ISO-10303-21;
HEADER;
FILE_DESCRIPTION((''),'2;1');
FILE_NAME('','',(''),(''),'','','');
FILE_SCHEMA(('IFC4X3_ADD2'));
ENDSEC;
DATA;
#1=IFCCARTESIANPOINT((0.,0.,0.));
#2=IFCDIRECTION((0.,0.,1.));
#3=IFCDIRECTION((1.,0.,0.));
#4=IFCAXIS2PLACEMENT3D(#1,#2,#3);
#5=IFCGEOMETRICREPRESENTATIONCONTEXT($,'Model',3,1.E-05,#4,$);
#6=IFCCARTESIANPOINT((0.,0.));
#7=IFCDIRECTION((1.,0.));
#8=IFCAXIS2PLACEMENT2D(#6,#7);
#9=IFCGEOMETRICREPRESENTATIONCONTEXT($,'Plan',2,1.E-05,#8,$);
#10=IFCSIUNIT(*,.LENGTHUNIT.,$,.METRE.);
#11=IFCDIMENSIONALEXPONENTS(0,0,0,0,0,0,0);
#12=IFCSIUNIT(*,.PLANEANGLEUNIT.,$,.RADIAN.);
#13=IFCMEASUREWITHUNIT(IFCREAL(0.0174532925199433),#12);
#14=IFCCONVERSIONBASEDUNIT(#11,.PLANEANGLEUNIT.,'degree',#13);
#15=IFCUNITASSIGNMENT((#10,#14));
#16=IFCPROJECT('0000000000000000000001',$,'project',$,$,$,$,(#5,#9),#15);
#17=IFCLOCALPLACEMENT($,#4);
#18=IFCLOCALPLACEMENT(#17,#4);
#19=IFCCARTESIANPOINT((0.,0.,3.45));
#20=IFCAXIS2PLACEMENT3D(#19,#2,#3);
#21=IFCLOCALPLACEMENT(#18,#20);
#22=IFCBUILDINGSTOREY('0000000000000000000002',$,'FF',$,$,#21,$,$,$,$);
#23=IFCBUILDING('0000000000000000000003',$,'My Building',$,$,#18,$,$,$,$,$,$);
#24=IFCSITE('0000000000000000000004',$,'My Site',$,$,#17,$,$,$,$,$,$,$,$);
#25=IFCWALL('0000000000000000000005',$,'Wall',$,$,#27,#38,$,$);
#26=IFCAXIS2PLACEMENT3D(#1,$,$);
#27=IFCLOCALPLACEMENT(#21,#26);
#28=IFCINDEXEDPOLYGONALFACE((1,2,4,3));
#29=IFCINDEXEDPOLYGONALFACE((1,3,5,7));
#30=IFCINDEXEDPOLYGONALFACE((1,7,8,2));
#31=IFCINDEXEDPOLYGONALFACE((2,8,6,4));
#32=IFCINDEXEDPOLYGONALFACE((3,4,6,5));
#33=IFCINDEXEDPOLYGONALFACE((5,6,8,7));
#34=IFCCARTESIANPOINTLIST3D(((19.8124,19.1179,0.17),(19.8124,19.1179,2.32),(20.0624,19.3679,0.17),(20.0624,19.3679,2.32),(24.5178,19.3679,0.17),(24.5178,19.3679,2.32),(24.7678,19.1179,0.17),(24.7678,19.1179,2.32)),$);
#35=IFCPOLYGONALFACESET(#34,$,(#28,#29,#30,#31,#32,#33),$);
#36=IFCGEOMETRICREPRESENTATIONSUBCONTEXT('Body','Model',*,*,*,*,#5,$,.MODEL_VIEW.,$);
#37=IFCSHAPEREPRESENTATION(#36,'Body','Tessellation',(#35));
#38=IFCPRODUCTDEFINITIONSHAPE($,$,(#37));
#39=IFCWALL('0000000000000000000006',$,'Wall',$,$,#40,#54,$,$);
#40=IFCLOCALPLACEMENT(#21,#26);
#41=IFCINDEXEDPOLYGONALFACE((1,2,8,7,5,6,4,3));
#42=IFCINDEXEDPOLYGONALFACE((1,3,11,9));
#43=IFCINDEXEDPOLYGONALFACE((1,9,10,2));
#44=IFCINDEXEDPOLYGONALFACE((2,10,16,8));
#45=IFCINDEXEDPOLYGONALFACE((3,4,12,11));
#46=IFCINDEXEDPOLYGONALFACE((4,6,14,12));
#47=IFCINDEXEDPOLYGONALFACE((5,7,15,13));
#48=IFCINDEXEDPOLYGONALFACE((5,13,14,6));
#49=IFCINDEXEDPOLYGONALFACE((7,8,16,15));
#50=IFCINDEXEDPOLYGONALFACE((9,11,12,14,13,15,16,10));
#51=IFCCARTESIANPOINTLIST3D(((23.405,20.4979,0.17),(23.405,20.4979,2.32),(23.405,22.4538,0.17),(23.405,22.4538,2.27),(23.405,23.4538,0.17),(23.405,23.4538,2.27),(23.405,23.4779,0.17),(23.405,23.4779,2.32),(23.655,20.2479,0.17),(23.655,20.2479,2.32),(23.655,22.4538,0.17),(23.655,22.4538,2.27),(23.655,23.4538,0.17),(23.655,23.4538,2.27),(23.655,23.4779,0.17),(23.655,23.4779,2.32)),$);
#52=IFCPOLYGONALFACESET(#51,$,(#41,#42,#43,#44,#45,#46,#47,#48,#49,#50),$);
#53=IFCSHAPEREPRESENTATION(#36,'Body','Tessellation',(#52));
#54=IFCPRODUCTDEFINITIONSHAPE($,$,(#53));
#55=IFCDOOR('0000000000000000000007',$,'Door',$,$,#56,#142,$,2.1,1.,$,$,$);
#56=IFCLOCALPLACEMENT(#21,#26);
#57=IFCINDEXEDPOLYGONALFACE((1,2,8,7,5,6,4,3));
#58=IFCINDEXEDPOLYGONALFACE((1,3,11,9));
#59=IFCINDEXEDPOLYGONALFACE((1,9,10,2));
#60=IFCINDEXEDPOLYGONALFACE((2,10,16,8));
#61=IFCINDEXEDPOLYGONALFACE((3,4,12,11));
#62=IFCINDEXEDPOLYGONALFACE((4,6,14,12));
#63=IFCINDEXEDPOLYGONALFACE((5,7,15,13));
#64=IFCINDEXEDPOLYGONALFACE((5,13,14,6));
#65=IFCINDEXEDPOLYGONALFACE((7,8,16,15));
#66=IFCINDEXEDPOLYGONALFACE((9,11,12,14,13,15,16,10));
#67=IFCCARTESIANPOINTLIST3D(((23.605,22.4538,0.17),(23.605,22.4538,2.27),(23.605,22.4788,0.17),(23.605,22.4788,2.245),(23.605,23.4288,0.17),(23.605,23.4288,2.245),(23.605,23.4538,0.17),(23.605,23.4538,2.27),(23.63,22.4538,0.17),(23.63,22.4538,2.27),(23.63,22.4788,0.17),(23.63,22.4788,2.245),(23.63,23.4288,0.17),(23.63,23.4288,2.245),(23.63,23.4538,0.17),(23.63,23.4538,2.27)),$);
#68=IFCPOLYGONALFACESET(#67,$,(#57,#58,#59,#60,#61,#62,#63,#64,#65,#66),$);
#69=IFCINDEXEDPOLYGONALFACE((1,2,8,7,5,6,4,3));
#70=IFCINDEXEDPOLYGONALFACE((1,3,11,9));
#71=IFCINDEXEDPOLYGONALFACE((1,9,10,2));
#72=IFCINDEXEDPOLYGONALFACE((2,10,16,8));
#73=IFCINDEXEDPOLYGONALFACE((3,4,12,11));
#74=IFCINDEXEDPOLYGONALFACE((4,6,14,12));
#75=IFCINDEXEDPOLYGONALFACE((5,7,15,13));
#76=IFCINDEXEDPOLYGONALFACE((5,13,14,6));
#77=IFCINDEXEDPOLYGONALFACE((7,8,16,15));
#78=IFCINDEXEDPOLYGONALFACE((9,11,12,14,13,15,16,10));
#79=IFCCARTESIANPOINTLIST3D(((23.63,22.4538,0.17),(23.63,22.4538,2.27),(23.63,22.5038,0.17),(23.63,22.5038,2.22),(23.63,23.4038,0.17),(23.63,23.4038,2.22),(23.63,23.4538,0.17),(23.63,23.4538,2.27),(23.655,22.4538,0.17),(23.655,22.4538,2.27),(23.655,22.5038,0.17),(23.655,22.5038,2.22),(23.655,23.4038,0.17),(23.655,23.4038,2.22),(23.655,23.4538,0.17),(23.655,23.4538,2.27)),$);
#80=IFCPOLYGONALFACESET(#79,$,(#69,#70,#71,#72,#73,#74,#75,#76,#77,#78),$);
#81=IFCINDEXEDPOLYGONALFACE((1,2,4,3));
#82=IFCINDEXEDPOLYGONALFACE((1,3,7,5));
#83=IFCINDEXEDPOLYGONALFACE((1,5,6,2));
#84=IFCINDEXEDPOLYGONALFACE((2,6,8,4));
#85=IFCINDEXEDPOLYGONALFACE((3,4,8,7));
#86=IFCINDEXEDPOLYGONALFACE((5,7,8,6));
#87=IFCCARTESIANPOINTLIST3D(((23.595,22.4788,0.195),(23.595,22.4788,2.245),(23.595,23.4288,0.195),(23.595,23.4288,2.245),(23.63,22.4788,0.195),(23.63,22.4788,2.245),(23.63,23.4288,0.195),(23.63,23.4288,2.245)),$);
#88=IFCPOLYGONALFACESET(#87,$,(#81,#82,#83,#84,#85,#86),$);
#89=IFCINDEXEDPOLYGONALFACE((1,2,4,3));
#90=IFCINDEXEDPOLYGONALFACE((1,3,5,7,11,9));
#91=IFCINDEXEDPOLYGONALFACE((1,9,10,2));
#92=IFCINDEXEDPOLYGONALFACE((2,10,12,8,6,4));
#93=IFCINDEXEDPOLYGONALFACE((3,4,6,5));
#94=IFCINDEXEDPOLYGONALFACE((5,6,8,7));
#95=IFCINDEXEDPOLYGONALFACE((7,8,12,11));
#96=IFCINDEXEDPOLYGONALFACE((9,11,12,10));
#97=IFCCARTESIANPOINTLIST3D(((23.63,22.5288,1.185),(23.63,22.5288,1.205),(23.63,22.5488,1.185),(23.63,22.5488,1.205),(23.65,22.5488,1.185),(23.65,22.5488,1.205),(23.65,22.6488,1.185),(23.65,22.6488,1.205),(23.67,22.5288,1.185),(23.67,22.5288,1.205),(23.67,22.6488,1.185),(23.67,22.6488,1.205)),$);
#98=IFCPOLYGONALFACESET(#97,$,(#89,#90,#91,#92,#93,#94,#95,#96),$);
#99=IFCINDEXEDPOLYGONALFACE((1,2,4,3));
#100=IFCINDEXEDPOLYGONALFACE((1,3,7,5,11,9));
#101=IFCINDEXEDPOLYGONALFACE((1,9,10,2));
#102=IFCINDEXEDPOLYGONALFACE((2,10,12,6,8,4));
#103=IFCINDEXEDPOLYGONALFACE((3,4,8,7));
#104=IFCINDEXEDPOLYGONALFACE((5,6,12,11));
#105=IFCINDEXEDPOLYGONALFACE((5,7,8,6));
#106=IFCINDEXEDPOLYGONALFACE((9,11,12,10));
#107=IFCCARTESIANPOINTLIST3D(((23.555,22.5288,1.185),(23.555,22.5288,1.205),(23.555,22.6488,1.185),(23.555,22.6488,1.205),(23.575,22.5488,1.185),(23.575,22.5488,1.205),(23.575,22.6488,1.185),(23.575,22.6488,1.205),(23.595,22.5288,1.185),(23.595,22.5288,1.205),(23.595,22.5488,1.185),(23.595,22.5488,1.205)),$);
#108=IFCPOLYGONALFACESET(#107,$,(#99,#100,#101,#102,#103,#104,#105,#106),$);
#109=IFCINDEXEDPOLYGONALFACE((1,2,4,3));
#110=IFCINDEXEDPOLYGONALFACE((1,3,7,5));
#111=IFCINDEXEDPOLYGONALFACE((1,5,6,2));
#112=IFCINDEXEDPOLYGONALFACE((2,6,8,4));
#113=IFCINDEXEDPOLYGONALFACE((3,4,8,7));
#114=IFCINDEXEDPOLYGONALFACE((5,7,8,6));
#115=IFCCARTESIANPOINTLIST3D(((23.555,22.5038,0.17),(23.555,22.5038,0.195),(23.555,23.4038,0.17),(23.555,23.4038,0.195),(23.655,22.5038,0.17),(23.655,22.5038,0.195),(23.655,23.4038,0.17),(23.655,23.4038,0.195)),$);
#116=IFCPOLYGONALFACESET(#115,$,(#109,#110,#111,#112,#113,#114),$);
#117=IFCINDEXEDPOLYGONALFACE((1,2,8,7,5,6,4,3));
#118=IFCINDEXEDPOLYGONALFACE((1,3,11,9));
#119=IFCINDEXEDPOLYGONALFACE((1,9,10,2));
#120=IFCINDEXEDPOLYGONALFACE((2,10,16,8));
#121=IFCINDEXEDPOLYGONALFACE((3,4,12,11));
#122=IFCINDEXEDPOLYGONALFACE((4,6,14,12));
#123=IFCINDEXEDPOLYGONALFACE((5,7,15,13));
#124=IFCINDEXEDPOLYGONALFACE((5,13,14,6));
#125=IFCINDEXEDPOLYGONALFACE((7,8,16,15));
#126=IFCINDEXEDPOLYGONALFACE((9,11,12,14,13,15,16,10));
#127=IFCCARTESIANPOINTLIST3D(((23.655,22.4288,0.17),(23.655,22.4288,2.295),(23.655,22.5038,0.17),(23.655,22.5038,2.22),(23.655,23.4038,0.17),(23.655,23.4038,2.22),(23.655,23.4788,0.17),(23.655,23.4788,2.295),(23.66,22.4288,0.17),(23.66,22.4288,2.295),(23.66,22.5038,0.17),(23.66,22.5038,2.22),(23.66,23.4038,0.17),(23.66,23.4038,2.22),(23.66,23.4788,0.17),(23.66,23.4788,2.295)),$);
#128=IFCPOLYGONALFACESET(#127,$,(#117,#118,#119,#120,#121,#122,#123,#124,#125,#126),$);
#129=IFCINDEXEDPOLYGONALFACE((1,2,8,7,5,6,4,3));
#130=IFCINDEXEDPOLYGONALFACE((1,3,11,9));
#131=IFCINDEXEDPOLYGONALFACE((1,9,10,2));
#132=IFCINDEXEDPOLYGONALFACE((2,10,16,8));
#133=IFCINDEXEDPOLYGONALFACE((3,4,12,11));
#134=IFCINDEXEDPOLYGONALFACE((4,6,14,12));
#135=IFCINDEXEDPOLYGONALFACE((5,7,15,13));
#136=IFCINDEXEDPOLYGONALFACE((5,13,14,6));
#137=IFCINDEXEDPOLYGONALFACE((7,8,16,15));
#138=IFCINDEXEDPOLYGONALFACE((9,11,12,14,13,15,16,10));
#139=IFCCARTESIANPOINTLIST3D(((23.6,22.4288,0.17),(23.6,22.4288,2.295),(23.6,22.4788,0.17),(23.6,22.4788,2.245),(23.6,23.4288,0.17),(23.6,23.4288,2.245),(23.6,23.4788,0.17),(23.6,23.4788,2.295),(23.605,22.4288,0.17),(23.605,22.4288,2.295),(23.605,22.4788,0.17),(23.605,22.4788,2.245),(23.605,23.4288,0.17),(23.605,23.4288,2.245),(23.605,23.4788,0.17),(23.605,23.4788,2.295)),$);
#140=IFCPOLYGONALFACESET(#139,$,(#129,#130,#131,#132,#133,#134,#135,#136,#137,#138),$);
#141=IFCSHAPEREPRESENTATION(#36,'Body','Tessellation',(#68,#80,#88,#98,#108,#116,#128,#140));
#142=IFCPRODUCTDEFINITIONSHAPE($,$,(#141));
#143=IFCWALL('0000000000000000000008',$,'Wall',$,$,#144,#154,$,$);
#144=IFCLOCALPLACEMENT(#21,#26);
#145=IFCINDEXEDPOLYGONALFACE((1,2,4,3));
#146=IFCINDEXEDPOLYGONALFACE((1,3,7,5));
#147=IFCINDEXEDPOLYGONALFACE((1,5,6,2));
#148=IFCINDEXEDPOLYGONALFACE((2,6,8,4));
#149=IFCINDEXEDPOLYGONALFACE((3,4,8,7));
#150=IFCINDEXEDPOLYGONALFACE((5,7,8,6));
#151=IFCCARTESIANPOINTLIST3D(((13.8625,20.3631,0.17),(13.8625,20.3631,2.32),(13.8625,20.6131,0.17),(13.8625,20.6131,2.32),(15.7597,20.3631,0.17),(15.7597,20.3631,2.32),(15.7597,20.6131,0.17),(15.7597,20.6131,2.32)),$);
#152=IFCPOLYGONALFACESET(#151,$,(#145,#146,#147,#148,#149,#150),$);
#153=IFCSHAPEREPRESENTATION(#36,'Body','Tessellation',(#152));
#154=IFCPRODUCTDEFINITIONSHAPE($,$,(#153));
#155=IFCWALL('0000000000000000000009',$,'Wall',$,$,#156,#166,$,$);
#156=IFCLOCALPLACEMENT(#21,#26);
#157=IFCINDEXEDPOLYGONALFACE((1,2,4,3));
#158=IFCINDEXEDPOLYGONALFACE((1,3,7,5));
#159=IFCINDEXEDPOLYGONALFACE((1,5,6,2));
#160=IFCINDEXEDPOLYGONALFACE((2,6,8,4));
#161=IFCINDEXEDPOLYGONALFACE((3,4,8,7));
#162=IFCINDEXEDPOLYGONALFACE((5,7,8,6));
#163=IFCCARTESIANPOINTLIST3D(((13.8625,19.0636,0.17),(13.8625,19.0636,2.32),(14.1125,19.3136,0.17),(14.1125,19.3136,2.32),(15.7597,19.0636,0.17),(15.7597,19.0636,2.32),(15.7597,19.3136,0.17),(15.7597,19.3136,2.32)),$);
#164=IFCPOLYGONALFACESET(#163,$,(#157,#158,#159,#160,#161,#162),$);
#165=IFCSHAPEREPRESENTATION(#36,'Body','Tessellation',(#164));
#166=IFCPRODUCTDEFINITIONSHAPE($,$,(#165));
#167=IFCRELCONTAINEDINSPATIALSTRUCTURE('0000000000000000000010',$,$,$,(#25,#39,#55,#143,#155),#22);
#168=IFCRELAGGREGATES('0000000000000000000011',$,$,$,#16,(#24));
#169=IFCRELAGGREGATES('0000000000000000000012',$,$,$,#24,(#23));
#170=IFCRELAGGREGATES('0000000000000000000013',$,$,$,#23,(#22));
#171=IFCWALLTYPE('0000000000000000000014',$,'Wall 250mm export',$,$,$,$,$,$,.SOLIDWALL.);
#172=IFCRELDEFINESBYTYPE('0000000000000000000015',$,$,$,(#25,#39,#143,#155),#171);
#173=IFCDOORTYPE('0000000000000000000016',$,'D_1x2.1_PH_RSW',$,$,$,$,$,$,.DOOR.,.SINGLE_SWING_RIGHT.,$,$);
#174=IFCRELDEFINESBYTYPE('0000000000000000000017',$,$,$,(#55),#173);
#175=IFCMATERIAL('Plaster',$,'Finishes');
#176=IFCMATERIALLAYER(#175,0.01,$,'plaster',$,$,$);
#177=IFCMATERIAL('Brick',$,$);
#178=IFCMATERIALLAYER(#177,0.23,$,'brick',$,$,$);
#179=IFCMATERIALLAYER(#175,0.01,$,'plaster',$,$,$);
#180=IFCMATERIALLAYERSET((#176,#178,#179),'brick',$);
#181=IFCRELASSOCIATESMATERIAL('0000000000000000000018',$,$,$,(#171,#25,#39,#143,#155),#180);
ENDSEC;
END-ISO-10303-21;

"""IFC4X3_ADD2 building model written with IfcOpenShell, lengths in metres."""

from ifc_helpers import new_model, entity, si_unit, converted_unit, frame, origin_with_axes, origin_2d_with_axis, place, context, subcontext, project, spatial, line, indexed_curve, outline, extrude, shape, source, transform, mapped, material, layer, layer_set, layer_usage, type_object, type_shapes, element, fill, save


model = new_model("IFC4X3_ADD2")

# Units and contexts
model_context = context("Model", 3, precision=1e-05, world=origin_with_axes())
plan_context = context("Plan", 2, precision=1e-05, world=origin_2d_with_axis())
body_context_1 = subcontext(model_context, "Body", "Model", "MODEL_VIEW")
body_context_2 = subcontext(plan_context, "Body", "Plan", "PLAN_VIEW")
ifc_project = project(units=[si_unit("LENGTHUNIT", "METRE"), converted_unit("PLANEANGLEUNIT", "degree", entity("IfcReal", 0.0174532925199433), si_unit("PLANEANGLEUNIT", "RADIAN"), dimensions=[0, 0, 0, 0, 0, 0, 0])], contexts=[model_context, plan_context])

# Site, building, storey
site_placement = place(None, origin_with_axes())
site = spatial("IfcSite", under=ifc_project, at=site_placement, Name="My Site")
building_placement = place(site_placement, origin_with_axes())
building = spatial("IfcBuilding", under=site, at=building_placement, Name="My Building")
storey_placement = place(building_placement, frame((0.0, 0.0, 3.45), z_axis=(0.0, 0.0, 1.0), x_axis=(1.0, 0.0, 0.0)))
storey = spatial("IfcBuildingStorey", under=building, at=storey_placement, Name="FF")

# Shared definitions
ifc_material_1 = material(Name="Plaster", Category="Finishes")
ifc_layer_1 = layer(ifc_material_1, 0.01, Name="plaster")
ifc_material_2 = material(Name="Brick")
ifc_layer_2 = layer(ifc_material_2, 0.23, Name="brick")
ifc_layer_3 = layer(ifc_material_1, 0.01, Name="plaster")
ifc_layer_set_1 = layer_set([ifc_layer_1, ifc_layer_2, ifc_layer_3], Name="brick")
wall_type_1 = type_object("IfcWallType", Name="Wall 250mm export", PredefinedType="SOLIDWALL", material=ifc_layer_set_1)

# Wall
ifc_layer_usage_1 = layer_usage(ifc_layer_set_1, "AXIS2", "POSITIVE", 0.0)
wall_1_placement = place(storey_placement, frame((20.0624, 19.1179, 0.17), z_axis=(0.0, 0.0, 1.0), x_axis=(1.0, 0.0, 0.0)))
element("IfcWall", 1, at=wall_1_placement, inside=storey, type_object=wall_type_1, material=ifc_layer_usage_1, Name="Wall", context=body_context_1, shape_type="SweptSolid", body=[
    extrude(outline(indexed_curve([(-0.25, 0.0), (0.0, 0.25), (4.4554, 0.25), (4.7054, 0.0)], segments=[line(1, 2, 3, 4, 1)])), origin_with_axes(), (0.0, 0.0, 1.0), 2.15),
])

# Wall, opening, door
ifc_layer_usage_2 = layer_usage(ifc_layer_set_1, "AXIS2", "POSITIVE", 0.0)
wall_2_placement = place(storey_placement, frame((23.655, 20.2479, 0.17), z_axis=(0.0, 0.0, 1.0), x_axis=(0.0, 1.0, 0.0)))
wall_2 = element("IfcWall", 2, at=wall_2_placement, inside=storey, type_object=wall_type_1, material=ifc_layer_usage_2, Name="Wall", context=body_context_1, shape_type="SweptSolid", body=[
    extrude(outline(indexed_curve([(0.0, 0.0), (0.25, 0.25), (3.23, 0.25), (3.23, 0.0)], segments=[line(1, 2, 3, 4, 1)])), origin_with_axes(), (0.0, 0.0, 1.0), 2.15),
])
shared_shape_1 = source(origin_with_axes(), body_context_1, "Body", "SweptSolid", [
    extrude(outline(indexed_curve([(0.0, 0.0), (1.0, 0.0), (1.0, 2.1), (0.0, 2.1)], segments=[line(1, 2, 3, 4, 1)])), frame((0.0, -0.6, 0.0), z_axis=(0.0, -1.0, 0.0), x_axis=(1.0, 0.0, 0.0)), (0.0, 0.0, -1.0), 1.2),
])
opening_1_placement = place(wall_2_placement, frame((2.2059, 0.0, 0.0), z_axis=(0.0, 0.0, 1.0), x_axis=(1.0, 0.0, 0.0)))
opening_1 = element("IfcOpeningElement", 3, at=opening_1_placement, cuts=wall_2, PredefinedType="OPENING", context=body_context_1, shape_type="MappedRepresentation", body=[
    mapped(shared_shape_1, transform((0.0, 0.0, 0.0), x_axis=(1.0, 0.0, 0.0), y_axis=(0.0, 1.0, 0.0), z_axis=(0.0, 0.0, 1.0), scale=1.0)),
])
door_type_1 = type_object("IfcDoorType", Name="D_1x2.1_PH_RSW", OperationType="SINGLE_SWING_RIGHT", PredefinedType="DOOR")
shared_shape_2 = source(origin_with_axes(), body_context_1, "Body", "SweptSolid", [
    extrude(outline(indexed_curve([(0.0, 0.0), (0.0, 2.1), (1.0, 2.1), (1.0, 0.0), (0.975, 0.0), (0.975, 2.075), (0.025, 2.075), (0.025, 0.0)], segments=[line(1, 2, 3, 4, 5, 6, 7, 8, 1)])), frame((0.0, 0.025, 0.0), z_axis=(0.0, -1.0, 0.0), x_axis=(1.0, 0.0, 0.0)), (0.0, 0.0, -1.0), 0.025),
    extrude(outline(indexed_curve([(0.0, 0.0), (0.0, 2.1), (1.0, 2.1), (1.0, 0.0), (0.95, 0.0), (0.95, 2.05), (0.05, 2.05), (0.05, 0.0)], segments=[line(1, 2, 3, 4, 5, 6, 7, 8, 1)])), frame((0.0, 0.0, 0.0), z_axis=(0.0, -1.0, 0.0), x_axis=(1.0, 0.0, 0.0)), (0.0, 0.0, -1.0), 0.025),
    extrude(outline(indexed_curve([(0.0, 0.0), (0.95, 0.0), (0.95, 0.035), (0.0, 0.035)], segments=[line(1, 2, 3, 4, 1)])), frame((0.025, 0.025, 0.025), z_axis=(0.0, 0.0, 1.0), x_axis=(1.0, 0.0, 0.0)), (0.0, 0.0, 1.0), 2.05),
    extrude(outline(indexed_curve([(0.0, 0.0), (0.0, -0.04), (0.12, -0.04), (0.12, -0.02), (0.02, -0.02), (0.02, 0.0)], segments=[line(1, 2, 3, 4, 5, 6, 1)])), frame((0.075, 0.025, 1.015), z_axis=(0.0, 0.0, 1.0), x_axis=(1.0, 0.0, 0.0)), (0.0, 0.0, 1.0), 0.02),
    extrude(outline(indexed_curve([(0.0, 0.0), (0.0, 0.04), (0.12, 0.04), (0.12, 0.02), (0.02, 0.02), (0.02, 0.0)], segments=[line(1, 2, 3, 4, 5, 6, 1)])), frame((0.075, 0.06, 1.015), z_axis=(0.0, 0.0, 1.0), x_axis=(1.0, 0.0, 0.0)), (0.0, 0.0, 1.0), 0.02),
    extrude(outline(indexed_curve([(0.0, 0.0), (0.9, 0.0), (0.9, 0.1), (0.0, 0.1)], segments=[line(1, 2, 3, 4, 1)])), frame((0.05, 0.0, 0.0), z_axis=(0.0, 0.0, 1.0), x_axis=(1.0, 0.0, 0.0)), (0.0, 0.0, 1.0), 0.025),
    extrude(outline(indexed_curve([(0.0, 0.0), (0.0, 2.125), (1.05, 2.125), (1.05, 0.0), (0.975, 0.0), (0.975, 2.05), (0.075, 2.05), (0.075, 0.0)], segments=[line(1, 2, 3, 4, 5, 6, 7, 8, 1)])), frame((-0.025, -0.005, 0.0), z_axis=(0.0, -1.0, 0.0), x_axis=(1.0, 0.0, 0.0)), (0.0, 0.0, -1.0), 0.005),
    extrude(outline(indexed_curve([(0.0, 0.0), (0.0, 2.125), (1.05, 2.125), (1.05, 0.0), (1.0, 0.0), (1.0, 2.075), (0.05, 2.075), (0.05, 0.0)], segments=[line(1, 2, 3, 4, 5, 6, 7, 8, 1)])), frame((-0.025, 0.05, 0.0), z_axis=(0.0, -1.0, 0.0), x_axis=(1.0, 0.0, 0.0)), (0.0, 0.0, -1.0), 0.005),
])
shared_shape_3 = source(origin_with_axes(), body_context_2, "Body", "Curve2D", [
    entity("IfcIndexedPolyCurve", entity("IfcCartesianPointList2D", [[0.0, 0.0], [0.0, 0.05], [0.025, 0.05], [0.025, 0.025], [0.05, 0.025], [0.05, 0.0]]), [entity("IfcLineIndex", [1, 2, 3, 4, 5, 6, 1])]),
    entity("IfcIndexedPolyCurve", entity("IfcCartesianPointList2D", [[1.0, 0.0], [1.0, 0.05], [0.975, 0.05], [0.975, 0.025], [0.95, 0.025], [0.95, 0.0]]), [entity("IfcLineIndex", [1, 2, 3, 4, 5, 6, 1])]),
    entity("IfcTrimmedCurve", entity("IfcEllipse", entity("IfcAxis2Placement2D", entity("IfcCartesianPoint", [0.94, 0.05]), entity("IfcDirection", [1.0, 0.0])), 0.915, 0.95), [entity("IfcCartesianPoint", [0.94, 1.0])], [entity("IfcCartesianPoint", [0.025, 0.05])], True, "CARTESIAN"),
    entity("IfcIndexedPolyCurve", entity("IfcCartesianPointList2D", [[0.975, 0.05], [0.94, 0.05], [0.94, 1.0], [0.975, 1.0]]), [entity("IfcLineIndex", [1, 2, 3, 4, 1])]),
])
type_shapes(door_type_1, [shared_shape_2, shared_shape_3])
door_1_placement = place(opening_1_placement, frame((0.0, 0.0, 0.0), z_axis=(0.0, 0.0, 1.0), x_axis=(1.0, 0.0, 0.0)))
door_1 = element("IfcDoor", 4, at=door_1_placement, inside=storey, type_object=door_type_1, Name="Door", OverallHeight=2.1, OverallWidth=1.0, shapes=[
    shape(body_context_1, "Body", "MappedRepresentation", [mapped(shared_shape_2, transform((0.0, 0.0, 0.0), x_axis=(1.0, 0.0, 0.0), y_axis=(0.0, 1.0, 0.0), z_axis=(0.0, 0.0, 1.0), scale=1.0))]),
    shape(body_context_2, "Body", "MappedRepresentation", [mapped(shared_shape_3, transform((0.0, 0.0, 0.0), x_axis=(1.0, 0.0, 0.0), y_axis=(0.0, 1.0, 0.0), z_axis=(0.0, 0.0, 1.0), scale=1.0))]),
])
fill(opening_1, door_1)

# Walls
ifc_layer_usage_3 = layer_usage(ifc_layer_set_1, "AXIS2", "POSITIVE", 0.0)
wall_3_placement = place(storey_placement, frame((13.8625, 20.3631, 0.17), z_axis=(0.0, 0.0, 1.0), x_axis=(1.0, 0.0, 0.0)))
element("IfcWall", 5, at=wall_3_placement, inside=storey, type_object=wall_type_1, material=ifc_layer_usage_3, Name="Wall", context=body_context_1, shape_type="SweptSolid", body=[
    extrude(outline(indexed_curve([(0.0, 0.0), (0.0, 0.25), (1.8972, 0.25), (1.8972, 0.0)], segments=[line(1, 2, 3, 4, 1)])), origin_with_axes(), (0.0, 0.0, 1.0), 2.15),
])
ifc_layer_usage_4 = layer_usage(ifc_layer_set_1, "AXIS2", "POSITIVE", 0.0)
wall_4_placement = place(storey_placement, frame((13.8625, 19.0636, 0.17), z_axis=(0.0, 0.0, 1.0), x_axis=(1.0, 0.0, 0.0)))
element("IfcWall", 6, at=wall_4_placement, inside=storey, type_object=wall_type_1, material=ifc_layer_usage_4, Name="Wall", context=body_context_1, shape_type="SweptSolid", body=[
    extrude(outline(indexed_curve([(0.0, 0.0), (0.25, 0.25), (1.8972, 0.25), (1.8972, 0.0)], segments=[line(1, 2, 3, 4, 1)])), origin_with_axes(), (0.0, 0.0, 1.0), 2.15),
])

save(model, "model.ifc")
